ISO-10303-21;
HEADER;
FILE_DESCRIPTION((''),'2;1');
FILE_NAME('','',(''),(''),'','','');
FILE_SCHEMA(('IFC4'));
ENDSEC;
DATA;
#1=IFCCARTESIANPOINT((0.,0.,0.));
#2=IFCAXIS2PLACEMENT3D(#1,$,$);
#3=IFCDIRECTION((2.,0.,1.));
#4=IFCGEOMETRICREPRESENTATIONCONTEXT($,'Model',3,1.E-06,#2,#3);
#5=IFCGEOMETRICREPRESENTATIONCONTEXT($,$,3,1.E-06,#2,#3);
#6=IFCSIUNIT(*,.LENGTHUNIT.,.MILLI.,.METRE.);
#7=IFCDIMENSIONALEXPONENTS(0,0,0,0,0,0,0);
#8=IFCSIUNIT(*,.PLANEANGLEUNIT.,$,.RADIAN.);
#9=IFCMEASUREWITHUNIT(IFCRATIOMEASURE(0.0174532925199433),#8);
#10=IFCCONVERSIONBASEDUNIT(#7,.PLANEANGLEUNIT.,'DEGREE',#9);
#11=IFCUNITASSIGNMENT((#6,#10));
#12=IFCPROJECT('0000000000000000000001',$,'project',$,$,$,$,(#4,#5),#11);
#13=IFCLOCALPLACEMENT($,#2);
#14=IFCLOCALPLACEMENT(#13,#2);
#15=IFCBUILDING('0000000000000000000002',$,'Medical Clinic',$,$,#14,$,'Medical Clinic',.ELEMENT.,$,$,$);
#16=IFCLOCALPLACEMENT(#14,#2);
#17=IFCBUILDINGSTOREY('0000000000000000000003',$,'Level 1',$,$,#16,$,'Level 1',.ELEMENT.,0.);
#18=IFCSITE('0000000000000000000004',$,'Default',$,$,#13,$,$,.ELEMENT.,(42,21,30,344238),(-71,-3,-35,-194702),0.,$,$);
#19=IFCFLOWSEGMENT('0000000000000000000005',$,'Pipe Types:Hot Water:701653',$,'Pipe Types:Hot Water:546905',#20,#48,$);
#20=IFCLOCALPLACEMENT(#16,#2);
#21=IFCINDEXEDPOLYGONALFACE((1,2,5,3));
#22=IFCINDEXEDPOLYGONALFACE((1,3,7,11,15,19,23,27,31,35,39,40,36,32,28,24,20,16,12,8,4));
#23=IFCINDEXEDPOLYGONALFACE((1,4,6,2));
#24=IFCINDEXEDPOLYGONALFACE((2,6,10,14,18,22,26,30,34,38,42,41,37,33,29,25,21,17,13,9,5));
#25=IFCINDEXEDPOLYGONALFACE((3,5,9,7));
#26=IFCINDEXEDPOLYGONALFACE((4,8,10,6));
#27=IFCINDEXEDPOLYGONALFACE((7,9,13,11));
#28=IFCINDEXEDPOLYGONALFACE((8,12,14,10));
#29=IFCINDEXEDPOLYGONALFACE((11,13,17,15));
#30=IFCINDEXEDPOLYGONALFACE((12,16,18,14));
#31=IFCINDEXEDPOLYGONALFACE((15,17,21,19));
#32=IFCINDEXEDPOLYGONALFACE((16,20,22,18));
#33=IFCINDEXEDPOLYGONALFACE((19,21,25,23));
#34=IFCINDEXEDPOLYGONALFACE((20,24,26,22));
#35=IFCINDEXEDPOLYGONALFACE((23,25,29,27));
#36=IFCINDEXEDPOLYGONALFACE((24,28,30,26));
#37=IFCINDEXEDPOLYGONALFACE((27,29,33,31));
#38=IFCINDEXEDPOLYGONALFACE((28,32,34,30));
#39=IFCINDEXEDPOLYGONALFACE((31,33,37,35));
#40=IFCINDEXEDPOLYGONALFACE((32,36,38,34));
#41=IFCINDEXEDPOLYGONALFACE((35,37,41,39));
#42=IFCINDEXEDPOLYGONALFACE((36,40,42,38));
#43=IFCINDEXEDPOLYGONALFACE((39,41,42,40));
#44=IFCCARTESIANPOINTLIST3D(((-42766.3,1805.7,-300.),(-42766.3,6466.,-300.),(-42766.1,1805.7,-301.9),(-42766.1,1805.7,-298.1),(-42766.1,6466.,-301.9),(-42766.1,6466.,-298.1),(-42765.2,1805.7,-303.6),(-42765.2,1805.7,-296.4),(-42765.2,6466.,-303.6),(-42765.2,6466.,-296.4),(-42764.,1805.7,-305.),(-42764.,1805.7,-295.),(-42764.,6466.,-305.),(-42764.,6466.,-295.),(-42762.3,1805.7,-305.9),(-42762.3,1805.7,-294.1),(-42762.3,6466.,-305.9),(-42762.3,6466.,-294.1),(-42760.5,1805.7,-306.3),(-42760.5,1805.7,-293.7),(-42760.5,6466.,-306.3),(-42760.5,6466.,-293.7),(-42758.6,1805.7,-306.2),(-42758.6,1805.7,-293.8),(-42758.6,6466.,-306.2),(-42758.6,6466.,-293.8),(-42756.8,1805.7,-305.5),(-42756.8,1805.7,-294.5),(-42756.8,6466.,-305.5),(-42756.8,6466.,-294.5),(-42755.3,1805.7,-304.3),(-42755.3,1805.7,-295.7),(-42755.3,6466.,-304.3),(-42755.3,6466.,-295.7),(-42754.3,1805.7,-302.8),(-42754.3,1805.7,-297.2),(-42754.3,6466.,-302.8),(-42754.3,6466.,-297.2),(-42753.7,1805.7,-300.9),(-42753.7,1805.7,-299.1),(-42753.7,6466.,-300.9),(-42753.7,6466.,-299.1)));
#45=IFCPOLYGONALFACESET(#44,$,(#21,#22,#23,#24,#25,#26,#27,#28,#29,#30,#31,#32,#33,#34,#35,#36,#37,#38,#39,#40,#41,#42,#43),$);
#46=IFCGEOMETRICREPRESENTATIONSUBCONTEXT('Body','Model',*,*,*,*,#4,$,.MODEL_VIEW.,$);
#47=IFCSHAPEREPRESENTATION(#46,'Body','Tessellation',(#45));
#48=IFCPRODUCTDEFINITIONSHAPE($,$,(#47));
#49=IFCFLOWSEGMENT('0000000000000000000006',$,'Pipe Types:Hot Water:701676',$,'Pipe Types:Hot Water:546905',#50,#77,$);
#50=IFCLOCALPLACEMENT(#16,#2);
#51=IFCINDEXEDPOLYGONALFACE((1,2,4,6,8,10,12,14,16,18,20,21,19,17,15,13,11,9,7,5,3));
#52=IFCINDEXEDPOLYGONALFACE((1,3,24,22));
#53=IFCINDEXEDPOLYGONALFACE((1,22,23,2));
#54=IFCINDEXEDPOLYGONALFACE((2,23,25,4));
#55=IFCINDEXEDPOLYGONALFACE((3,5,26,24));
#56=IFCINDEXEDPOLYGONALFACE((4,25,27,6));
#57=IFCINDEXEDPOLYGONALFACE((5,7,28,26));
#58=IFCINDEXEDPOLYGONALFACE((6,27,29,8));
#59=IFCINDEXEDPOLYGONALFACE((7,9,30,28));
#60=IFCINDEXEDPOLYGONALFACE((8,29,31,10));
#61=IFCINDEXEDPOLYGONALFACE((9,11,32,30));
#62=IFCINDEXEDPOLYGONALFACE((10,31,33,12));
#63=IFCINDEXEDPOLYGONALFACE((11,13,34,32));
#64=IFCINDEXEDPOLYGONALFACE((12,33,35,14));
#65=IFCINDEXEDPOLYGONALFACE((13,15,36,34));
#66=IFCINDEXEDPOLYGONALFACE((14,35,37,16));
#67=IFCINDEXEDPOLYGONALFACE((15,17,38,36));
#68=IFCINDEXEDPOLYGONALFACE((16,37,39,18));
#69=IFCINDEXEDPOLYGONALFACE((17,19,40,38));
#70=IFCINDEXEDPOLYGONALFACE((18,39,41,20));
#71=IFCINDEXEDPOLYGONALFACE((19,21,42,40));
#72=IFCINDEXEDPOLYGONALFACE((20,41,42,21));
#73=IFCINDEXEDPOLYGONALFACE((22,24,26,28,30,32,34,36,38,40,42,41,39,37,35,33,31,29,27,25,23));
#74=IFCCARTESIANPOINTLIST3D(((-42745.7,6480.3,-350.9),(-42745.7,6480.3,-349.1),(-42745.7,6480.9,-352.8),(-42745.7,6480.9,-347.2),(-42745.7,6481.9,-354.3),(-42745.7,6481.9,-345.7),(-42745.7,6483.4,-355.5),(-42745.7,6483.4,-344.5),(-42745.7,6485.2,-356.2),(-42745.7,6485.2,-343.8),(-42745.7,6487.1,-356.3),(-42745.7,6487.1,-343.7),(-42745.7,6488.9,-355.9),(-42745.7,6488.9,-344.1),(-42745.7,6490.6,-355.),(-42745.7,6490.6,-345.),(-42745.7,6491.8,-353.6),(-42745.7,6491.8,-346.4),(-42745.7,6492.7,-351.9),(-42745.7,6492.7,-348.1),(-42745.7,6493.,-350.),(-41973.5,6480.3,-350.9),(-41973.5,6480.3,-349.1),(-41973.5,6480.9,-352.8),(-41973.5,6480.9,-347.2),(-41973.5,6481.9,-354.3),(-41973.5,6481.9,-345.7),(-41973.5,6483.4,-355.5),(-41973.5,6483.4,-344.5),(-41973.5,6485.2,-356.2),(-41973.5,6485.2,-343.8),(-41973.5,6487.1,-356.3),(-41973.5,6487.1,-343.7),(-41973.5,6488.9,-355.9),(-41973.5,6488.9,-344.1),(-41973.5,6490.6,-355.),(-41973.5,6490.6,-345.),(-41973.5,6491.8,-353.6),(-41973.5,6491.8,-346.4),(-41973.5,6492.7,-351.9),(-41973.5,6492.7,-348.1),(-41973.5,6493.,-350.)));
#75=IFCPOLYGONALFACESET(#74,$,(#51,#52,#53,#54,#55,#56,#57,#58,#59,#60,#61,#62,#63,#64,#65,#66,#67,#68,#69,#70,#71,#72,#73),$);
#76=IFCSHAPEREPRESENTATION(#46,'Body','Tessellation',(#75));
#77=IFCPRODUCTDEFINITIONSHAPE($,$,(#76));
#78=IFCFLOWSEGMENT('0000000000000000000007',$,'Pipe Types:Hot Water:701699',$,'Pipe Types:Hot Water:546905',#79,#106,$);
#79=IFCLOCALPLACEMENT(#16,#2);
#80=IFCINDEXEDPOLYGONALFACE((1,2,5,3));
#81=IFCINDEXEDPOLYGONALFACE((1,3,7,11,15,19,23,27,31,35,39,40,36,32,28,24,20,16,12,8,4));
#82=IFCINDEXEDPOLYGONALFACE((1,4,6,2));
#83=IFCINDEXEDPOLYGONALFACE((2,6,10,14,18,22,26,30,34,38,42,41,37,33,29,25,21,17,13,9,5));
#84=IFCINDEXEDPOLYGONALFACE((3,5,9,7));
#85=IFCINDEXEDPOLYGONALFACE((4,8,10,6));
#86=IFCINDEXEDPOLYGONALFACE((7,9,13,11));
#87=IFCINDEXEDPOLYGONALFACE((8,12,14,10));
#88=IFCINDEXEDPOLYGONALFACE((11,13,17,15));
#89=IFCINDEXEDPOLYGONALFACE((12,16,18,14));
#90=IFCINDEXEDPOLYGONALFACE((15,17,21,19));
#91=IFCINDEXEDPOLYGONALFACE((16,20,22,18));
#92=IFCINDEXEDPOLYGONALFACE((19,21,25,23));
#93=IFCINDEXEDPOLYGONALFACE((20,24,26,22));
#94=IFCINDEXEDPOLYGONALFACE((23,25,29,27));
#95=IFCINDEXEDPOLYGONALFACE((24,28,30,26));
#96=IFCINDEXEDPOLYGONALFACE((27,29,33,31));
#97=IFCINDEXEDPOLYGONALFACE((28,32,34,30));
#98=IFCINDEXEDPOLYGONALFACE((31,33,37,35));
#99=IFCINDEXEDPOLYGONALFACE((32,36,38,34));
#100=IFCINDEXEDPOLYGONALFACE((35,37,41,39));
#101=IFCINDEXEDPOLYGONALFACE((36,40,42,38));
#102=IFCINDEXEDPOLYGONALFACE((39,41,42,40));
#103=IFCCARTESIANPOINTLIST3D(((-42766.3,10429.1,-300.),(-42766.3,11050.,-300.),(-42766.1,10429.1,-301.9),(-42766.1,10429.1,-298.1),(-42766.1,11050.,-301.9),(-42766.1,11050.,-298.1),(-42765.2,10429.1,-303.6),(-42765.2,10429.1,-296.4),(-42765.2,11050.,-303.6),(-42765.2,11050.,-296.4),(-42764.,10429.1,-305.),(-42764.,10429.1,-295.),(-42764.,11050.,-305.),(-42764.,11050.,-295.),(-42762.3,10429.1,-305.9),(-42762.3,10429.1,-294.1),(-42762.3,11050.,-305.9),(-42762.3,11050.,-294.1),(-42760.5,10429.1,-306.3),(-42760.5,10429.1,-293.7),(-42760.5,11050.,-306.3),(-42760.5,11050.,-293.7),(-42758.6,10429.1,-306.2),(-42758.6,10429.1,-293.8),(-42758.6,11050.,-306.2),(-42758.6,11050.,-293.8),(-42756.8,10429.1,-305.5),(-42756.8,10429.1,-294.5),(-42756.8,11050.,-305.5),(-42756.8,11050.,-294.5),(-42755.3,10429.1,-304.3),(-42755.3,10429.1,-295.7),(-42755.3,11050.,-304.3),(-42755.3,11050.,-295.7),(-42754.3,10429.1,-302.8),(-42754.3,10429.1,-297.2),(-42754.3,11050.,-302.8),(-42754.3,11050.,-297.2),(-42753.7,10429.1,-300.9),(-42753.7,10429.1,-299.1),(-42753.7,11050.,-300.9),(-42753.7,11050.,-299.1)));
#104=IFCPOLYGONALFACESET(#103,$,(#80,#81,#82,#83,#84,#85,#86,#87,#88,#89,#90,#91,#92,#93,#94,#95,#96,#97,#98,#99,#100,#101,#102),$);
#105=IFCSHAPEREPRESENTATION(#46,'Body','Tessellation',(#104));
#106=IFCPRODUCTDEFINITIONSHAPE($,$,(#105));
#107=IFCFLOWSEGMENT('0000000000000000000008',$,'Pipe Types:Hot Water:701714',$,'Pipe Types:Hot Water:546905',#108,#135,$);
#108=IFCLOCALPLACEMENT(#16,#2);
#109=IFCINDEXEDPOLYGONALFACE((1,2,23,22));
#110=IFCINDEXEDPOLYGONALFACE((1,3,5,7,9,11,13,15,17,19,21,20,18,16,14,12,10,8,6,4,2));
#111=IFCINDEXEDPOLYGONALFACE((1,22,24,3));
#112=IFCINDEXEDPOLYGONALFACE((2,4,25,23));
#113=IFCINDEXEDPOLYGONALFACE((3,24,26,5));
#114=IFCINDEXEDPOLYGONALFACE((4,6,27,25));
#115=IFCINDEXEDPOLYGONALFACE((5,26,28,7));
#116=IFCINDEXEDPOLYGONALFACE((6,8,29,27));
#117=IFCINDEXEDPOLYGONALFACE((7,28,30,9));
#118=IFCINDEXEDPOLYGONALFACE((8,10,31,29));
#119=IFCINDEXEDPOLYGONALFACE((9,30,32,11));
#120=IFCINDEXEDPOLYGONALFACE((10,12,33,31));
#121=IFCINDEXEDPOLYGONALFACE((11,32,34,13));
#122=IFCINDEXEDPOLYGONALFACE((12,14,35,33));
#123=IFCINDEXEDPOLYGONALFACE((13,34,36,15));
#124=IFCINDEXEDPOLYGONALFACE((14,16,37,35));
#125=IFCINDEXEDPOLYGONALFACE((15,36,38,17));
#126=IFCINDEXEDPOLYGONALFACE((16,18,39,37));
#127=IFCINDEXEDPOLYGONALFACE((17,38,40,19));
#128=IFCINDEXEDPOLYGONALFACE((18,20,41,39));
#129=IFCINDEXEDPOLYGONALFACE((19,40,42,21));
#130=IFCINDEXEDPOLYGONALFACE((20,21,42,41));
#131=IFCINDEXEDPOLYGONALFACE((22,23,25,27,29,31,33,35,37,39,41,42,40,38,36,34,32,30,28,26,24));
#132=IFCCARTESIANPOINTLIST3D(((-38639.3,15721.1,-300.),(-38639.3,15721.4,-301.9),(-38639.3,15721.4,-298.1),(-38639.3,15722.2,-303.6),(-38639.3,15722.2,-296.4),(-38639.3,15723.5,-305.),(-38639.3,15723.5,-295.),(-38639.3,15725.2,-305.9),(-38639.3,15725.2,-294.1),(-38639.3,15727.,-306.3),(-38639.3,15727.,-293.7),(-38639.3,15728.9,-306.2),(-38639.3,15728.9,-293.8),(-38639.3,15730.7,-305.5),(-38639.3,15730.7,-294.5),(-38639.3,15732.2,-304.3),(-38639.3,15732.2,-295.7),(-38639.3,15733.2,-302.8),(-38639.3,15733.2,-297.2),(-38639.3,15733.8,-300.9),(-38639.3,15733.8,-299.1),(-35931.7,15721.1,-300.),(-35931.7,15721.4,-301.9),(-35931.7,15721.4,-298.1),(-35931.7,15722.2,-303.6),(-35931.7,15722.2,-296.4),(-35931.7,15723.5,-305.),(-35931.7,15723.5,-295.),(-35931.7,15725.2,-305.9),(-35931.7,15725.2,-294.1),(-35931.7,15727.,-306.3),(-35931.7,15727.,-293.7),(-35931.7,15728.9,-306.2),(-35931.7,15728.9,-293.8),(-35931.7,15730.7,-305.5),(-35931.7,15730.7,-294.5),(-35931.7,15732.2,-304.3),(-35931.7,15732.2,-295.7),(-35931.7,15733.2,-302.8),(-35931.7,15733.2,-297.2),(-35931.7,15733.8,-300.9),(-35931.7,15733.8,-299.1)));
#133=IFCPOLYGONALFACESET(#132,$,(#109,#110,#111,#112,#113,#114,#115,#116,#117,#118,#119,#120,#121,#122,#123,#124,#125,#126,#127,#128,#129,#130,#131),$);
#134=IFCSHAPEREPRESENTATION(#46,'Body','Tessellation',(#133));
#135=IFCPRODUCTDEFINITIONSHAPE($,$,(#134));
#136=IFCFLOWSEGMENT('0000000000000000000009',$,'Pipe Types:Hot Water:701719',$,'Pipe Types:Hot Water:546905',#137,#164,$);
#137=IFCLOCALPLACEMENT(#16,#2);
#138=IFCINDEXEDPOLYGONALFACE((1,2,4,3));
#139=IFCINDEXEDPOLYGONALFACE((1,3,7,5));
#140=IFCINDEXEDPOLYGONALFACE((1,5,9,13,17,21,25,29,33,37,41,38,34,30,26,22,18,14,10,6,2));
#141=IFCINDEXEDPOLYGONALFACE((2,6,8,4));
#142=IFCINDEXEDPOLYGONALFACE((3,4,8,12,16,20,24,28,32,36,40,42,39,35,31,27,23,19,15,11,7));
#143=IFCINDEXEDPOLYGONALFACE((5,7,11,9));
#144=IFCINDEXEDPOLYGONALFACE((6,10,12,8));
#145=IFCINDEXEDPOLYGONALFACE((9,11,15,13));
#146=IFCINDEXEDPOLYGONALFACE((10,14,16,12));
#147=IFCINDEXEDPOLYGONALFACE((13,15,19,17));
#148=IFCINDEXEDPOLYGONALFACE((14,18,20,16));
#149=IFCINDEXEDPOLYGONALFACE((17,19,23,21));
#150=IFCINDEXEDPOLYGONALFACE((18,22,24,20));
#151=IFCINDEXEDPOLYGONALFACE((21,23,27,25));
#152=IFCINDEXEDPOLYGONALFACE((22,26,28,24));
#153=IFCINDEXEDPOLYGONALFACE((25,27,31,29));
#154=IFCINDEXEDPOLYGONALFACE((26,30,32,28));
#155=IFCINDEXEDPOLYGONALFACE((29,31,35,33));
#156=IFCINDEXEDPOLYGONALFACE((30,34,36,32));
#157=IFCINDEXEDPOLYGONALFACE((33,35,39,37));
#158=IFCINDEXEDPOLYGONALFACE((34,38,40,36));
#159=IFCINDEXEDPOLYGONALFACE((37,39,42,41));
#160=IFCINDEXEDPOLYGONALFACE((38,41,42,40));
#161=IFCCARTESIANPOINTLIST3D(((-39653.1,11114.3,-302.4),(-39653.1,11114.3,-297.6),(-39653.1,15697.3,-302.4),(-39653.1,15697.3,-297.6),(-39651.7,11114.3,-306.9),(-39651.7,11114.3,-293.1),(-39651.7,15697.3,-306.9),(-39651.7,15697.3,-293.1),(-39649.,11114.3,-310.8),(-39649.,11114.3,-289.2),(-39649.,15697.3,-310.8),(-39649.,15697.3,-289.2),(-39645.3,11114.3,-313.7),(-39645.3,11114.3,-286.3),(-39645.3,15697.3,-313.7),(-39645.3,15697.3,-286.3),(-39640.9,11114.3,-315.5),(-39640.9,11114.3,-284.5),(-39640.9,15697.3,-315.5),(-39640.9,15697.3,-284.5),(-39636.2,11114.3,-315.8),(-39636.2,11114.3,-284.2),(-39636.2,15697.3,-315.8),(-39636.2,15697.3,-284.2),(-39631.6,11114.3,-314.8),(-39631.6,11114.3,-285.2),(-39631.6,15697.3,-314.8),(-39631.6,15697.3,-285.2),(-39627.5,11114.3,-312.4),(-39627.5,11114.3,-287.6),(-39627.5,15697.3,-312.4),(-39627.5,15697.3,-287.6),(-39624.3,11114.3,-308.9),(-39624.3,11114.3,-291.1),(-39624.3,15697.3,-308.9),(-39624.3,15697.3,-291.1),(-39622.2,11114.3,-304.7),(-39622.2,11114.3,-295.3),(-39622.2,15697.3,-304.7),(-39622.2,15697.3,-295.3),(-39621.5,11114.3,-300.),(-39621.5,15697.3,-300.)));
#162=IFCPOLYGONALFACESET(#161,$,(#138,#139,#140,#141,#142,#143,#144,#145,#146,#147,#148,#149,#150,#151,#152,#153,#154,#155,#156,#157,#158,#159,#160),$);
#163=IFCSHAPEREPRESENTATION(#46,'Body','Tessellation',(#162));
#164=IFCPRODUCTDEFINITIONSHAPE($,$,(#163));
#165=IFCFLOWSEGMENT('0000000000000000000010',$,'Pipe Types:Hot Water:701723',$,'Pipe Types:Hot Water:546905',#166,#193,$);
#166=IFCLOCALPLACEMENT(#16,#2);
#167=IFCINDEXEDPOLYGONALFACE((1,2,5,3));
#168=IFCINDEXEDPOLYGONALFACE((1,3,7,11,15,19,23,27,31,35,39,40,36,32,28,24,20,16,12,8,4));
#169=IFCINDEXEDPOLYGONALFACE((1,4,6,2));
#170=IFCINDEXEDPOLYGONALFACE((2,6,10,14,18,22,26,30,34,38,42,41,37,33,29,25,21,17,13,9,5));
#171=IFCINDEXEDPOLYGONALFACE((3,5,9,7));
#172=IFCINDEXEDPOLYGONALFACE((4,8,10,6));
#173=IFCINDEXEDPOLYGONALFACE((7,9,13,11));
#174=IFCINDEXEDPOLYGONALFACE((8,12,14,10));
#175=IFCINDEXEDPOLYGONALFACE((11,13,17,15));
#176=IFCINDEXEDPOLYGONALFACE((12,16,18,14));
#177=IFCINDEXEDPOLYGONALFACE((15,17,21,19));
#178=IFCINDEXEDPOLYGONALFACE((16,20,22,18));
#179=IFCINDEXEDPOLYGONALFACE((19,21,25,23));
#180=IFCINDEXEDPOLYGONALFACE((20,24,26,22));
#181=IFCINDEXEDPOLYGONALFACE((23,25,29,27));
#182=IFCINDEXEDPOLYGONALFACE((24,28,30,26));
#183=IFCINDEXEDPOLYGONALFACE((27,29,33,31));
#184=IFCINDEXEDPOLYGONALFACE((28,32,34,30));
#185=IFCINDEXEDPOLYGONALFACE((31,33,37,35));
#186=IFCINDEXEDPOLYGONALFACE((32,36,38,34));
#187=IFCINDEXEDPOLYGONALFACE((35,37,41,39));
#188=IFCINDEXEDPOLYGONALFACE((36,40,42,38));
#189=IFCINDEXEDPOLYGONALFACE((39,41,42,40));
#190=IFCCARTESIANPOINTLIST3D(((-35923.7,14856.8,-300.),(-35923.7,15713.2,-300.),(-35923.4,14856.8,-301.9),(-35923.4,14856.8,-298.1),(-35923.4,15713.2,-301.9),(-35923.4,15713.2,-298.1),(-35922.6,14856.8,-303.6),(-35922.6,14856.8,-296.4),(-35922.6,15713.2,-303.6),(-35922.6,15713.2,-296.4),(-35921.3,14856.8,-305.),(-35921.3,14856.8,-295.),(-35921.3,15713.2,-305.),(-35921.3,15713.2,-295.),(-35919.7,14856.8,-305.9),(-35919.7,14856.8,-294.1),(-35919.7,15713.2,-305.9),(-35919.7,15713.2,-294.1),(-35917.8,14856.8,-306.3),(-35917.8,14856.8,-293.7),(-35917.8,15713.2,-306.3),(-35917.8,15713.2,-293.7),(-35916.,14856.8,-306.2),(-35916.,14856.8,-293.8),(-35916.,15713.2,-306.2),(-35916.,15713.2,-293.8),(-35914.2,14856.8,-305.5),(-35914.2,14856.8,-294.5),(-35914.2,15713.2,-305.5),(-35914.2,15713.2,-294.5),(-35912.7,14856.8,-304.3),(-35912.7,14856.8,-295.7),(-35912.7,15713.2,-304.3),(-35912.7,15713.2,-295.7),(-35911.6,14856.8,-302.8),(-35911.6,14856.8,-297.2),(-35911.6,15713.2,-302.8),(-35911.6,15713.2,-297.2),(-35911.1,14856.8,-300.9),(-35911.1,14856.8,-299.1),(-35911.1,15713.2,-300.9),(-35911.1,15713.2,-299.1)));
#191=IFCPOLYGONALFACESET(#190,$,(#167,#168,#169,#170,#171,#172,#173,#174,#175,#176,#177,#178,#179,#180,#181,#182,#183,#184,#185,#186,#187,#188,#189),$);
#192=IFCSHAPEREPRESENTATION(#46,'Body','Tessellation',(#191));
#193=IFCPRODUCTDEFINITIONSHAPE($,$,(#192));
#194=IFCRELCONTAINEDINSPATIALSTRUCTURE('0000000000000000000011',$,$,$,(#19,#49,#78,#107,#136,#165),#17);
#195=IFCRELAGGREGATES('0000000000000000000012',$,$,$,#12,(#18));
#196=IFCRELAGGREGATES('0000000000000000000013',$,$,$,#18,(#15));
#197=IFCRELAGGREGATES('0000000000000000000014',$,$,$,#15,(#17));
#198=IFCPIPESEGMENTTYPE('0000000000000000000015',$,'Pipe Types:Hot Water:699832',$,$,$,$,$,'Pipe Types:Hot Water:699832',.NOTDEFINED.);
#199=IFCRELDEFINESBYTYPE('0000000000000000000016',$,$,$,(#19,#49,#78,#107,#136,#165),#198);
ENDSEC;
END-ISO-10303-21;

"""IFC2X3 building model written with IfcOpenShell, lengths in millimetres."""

from ifc_helpers import new_model, entity, si_unit, converted_unit, direction, frame, frame_2d, origin, origin_2d_with_axis, place, context, subcontext, project, spatial, circle, extrude, type_object, element, save


model = new_model("IFC2X3")

# Units and contexts
model_context = context("Model", 3, precision=1e-06, world=origin(), true_north=direction((2.0, 0.0, 1.0)))
context_of_model = context(None, 3, precision=1e-06, world=origin(), true_north=direction((2.0, 0.0, 1.0)))
body_context = subcontext(model_context, "Body", "Model", "MODEL_VIEW")
ifc_project = project(units=[si_unit("LENGTHUNIT", "METRE", prefix="MILLI"), converted_unit("PLANEANGLEUNIT", "DEGREE", entity("IfcRatioMeasure", 0.0174532925199433), si_unit("PLANEANGLEUNIT", "RADIAN"), dimensions=[0, 0, 0, 0, 0, 0, 0])], contexts=[model_context, context_of_model])

# Site, building, storey
site_placement = place(None, origin())
site = spatial("IfcSite", under=ifc_project, at=site_placement, Name="Default", CompositionType="ELEMENT", RefLatitude=(42, 21, 30, 344238), RefLongitude=(-71, -3, -35, -194702), RefElevation=0.0)
building_placement = place(site_placement, origin())
building = spatial("IfcBuilding", under=site, at=building_placement, Name="Medical Clinic", LongName="Medical Clinic", CompositionType="ELEMENT")
storey_placement = place(building_placement, origin())
storey = spatial("IfcBuildingStorey", under=building, at=storey_placement, Name="Level 1", LongName="Level 1", CompositionType="ELEMENT", Elevation=0.0)

# Flow segments
pipe_segment_type_1 = type_object("IfcPipeSegmentType", Name="Pipe Types:Hot Water:699832", ElementType="Pipe Types:Hot Water:699832", PredefinedType="NOTDEFINED")
flow_segment_1_placement = place(storey_placement, origin())
element("IfcFlowSegment", 1, at=flow_segment_1_placement, inside=storey, type_object=pipe_segment_type_1, Name="Pipe Types:Hot Water:701653", ObjectType="Pipe Types:Hot Water:546905", context=body_context, shape_type="SweptSolid", body=[
    extrude(circle(Radius=6.3, at=frame_2d((0.0, 0.0), x_axis=(1.0, 0.0))), frame((-42760.0, 1805.7, -300.0), z_axis=(0.0, 1.0, 0.0), x_axis=(-1.0, 0.0, 0.0)), (0.0, 0.0, 1.0), 4660.3),
])
flow_segment_2_placement = place(storey_placement, origin())
element("IfcFlowSegment", 2, at=flow_segment_2_placement, inside=storey, type_object=pipe_segment_type_1, Name="Pipe Types:Hot Water:701676", ObjectType="Pipe Types:Hot Water:546905", context=body_context, shape_type="SweptSolid", body=[
    extrude(circle(Radius=6.3, at=frame_2d((0.0, 0.0), x_axis=(1.0, 0.0))), frame((-42745.7, 6486.6, -350.0), z_axis=(1.0, 0.0, 0.0), x_axis=(0.0, 1.0, 0.0)), (0.0, 0.0, 1.0), 772.3),
])
flow_segment_3_placement = place(storey_placement, origin())
element("IfcFlowSegment", 3, at=flow_segment_3_placement, inside=storey, type_object=pipe_segment_type_1, Name="Pipe Types:Hot Water:701699", ObjectType="Pipe Types:Hot Water:546905", context=body_context, shape_type="SweptSolid", body=[
    extrude(circle(Radius=6.3, at=frame_2d((0.0, 0.0), x_axis=(1.0, 0.0))), frame((-42760.0, 10429.1, -300.0), z_axis=(0.0, 1.0, 0.0), x_axis=(-1.0, 0.0, 0.0)), (0.0, 0.0, 1.0), 620.8),
])
flow_segment_4_placement = place(storey_placement, origin())
element("IfcFlowSegment", 4, at=flow_segment_4_placement, inside=storey, type_object=pipe_segment_type_1, Name="Pipe Types:Hot Water:701714", ObjectType="Pipe Types:Hot Water:546905", context=body_context, shape_type="SweptSolid", body=[
    extrude(circle(Radius=6.3, at=origin_2d_with_axis()), frame((-38639.3, 15727.5, -300.0), z_axis=(1.0, 0.0, 0.0), x_axis=(0.0, -1.0, 0.0)), (0.0, 0.0, 1.0), 2707.7),
])
flow_segment_5_placement = place(storey_placement, origin())
element("IfcFlowSegment", 5, at=flow_segment_5_placement, inside=storey, type_object=pipe_segment_type_1, Name="Pipe Types:Hot Water:701719", ObjectType="Pipe Types:Hot Water:546905", context=body_context, shape_type="SweptSolid", body=[
    extrude(circle(Radius=15.9, at=origin_2d_with_axis()), frame((-39637.4, 11114.3, -300.0), z_axis=(0.0, 1.0, 0.0), x_axis=(1.0, 0.0, 0.0)), (0.0, 0.0, 1.0), 4583.1),
])
flow_segment_6_placement = place(storey_placement, origin())
element("IfcFlowSegment", 6, at=flow_segment_6_placement, inside=storey, type_object=pipe_segment_type_1, Name="Pipe Types:Hot Water:701723", ObjectType="Pipe Types:Hot Water:546905", context=body_context, shape_type="SweptSolid", body=[
    extrude(circle(Radius=6.3, at=frame_2d((0.0, 0.0), x_axis=(1.0, 0.0))), frame((-35917.4, 14856.8, -300.0), z_axis=(0.0, 1.0, 0.0), x_axis=(-1.0, 0.0, 0.0)), (0.0, 0.0, 1.0), 856.4),
])

save(model, "model.ifc")
